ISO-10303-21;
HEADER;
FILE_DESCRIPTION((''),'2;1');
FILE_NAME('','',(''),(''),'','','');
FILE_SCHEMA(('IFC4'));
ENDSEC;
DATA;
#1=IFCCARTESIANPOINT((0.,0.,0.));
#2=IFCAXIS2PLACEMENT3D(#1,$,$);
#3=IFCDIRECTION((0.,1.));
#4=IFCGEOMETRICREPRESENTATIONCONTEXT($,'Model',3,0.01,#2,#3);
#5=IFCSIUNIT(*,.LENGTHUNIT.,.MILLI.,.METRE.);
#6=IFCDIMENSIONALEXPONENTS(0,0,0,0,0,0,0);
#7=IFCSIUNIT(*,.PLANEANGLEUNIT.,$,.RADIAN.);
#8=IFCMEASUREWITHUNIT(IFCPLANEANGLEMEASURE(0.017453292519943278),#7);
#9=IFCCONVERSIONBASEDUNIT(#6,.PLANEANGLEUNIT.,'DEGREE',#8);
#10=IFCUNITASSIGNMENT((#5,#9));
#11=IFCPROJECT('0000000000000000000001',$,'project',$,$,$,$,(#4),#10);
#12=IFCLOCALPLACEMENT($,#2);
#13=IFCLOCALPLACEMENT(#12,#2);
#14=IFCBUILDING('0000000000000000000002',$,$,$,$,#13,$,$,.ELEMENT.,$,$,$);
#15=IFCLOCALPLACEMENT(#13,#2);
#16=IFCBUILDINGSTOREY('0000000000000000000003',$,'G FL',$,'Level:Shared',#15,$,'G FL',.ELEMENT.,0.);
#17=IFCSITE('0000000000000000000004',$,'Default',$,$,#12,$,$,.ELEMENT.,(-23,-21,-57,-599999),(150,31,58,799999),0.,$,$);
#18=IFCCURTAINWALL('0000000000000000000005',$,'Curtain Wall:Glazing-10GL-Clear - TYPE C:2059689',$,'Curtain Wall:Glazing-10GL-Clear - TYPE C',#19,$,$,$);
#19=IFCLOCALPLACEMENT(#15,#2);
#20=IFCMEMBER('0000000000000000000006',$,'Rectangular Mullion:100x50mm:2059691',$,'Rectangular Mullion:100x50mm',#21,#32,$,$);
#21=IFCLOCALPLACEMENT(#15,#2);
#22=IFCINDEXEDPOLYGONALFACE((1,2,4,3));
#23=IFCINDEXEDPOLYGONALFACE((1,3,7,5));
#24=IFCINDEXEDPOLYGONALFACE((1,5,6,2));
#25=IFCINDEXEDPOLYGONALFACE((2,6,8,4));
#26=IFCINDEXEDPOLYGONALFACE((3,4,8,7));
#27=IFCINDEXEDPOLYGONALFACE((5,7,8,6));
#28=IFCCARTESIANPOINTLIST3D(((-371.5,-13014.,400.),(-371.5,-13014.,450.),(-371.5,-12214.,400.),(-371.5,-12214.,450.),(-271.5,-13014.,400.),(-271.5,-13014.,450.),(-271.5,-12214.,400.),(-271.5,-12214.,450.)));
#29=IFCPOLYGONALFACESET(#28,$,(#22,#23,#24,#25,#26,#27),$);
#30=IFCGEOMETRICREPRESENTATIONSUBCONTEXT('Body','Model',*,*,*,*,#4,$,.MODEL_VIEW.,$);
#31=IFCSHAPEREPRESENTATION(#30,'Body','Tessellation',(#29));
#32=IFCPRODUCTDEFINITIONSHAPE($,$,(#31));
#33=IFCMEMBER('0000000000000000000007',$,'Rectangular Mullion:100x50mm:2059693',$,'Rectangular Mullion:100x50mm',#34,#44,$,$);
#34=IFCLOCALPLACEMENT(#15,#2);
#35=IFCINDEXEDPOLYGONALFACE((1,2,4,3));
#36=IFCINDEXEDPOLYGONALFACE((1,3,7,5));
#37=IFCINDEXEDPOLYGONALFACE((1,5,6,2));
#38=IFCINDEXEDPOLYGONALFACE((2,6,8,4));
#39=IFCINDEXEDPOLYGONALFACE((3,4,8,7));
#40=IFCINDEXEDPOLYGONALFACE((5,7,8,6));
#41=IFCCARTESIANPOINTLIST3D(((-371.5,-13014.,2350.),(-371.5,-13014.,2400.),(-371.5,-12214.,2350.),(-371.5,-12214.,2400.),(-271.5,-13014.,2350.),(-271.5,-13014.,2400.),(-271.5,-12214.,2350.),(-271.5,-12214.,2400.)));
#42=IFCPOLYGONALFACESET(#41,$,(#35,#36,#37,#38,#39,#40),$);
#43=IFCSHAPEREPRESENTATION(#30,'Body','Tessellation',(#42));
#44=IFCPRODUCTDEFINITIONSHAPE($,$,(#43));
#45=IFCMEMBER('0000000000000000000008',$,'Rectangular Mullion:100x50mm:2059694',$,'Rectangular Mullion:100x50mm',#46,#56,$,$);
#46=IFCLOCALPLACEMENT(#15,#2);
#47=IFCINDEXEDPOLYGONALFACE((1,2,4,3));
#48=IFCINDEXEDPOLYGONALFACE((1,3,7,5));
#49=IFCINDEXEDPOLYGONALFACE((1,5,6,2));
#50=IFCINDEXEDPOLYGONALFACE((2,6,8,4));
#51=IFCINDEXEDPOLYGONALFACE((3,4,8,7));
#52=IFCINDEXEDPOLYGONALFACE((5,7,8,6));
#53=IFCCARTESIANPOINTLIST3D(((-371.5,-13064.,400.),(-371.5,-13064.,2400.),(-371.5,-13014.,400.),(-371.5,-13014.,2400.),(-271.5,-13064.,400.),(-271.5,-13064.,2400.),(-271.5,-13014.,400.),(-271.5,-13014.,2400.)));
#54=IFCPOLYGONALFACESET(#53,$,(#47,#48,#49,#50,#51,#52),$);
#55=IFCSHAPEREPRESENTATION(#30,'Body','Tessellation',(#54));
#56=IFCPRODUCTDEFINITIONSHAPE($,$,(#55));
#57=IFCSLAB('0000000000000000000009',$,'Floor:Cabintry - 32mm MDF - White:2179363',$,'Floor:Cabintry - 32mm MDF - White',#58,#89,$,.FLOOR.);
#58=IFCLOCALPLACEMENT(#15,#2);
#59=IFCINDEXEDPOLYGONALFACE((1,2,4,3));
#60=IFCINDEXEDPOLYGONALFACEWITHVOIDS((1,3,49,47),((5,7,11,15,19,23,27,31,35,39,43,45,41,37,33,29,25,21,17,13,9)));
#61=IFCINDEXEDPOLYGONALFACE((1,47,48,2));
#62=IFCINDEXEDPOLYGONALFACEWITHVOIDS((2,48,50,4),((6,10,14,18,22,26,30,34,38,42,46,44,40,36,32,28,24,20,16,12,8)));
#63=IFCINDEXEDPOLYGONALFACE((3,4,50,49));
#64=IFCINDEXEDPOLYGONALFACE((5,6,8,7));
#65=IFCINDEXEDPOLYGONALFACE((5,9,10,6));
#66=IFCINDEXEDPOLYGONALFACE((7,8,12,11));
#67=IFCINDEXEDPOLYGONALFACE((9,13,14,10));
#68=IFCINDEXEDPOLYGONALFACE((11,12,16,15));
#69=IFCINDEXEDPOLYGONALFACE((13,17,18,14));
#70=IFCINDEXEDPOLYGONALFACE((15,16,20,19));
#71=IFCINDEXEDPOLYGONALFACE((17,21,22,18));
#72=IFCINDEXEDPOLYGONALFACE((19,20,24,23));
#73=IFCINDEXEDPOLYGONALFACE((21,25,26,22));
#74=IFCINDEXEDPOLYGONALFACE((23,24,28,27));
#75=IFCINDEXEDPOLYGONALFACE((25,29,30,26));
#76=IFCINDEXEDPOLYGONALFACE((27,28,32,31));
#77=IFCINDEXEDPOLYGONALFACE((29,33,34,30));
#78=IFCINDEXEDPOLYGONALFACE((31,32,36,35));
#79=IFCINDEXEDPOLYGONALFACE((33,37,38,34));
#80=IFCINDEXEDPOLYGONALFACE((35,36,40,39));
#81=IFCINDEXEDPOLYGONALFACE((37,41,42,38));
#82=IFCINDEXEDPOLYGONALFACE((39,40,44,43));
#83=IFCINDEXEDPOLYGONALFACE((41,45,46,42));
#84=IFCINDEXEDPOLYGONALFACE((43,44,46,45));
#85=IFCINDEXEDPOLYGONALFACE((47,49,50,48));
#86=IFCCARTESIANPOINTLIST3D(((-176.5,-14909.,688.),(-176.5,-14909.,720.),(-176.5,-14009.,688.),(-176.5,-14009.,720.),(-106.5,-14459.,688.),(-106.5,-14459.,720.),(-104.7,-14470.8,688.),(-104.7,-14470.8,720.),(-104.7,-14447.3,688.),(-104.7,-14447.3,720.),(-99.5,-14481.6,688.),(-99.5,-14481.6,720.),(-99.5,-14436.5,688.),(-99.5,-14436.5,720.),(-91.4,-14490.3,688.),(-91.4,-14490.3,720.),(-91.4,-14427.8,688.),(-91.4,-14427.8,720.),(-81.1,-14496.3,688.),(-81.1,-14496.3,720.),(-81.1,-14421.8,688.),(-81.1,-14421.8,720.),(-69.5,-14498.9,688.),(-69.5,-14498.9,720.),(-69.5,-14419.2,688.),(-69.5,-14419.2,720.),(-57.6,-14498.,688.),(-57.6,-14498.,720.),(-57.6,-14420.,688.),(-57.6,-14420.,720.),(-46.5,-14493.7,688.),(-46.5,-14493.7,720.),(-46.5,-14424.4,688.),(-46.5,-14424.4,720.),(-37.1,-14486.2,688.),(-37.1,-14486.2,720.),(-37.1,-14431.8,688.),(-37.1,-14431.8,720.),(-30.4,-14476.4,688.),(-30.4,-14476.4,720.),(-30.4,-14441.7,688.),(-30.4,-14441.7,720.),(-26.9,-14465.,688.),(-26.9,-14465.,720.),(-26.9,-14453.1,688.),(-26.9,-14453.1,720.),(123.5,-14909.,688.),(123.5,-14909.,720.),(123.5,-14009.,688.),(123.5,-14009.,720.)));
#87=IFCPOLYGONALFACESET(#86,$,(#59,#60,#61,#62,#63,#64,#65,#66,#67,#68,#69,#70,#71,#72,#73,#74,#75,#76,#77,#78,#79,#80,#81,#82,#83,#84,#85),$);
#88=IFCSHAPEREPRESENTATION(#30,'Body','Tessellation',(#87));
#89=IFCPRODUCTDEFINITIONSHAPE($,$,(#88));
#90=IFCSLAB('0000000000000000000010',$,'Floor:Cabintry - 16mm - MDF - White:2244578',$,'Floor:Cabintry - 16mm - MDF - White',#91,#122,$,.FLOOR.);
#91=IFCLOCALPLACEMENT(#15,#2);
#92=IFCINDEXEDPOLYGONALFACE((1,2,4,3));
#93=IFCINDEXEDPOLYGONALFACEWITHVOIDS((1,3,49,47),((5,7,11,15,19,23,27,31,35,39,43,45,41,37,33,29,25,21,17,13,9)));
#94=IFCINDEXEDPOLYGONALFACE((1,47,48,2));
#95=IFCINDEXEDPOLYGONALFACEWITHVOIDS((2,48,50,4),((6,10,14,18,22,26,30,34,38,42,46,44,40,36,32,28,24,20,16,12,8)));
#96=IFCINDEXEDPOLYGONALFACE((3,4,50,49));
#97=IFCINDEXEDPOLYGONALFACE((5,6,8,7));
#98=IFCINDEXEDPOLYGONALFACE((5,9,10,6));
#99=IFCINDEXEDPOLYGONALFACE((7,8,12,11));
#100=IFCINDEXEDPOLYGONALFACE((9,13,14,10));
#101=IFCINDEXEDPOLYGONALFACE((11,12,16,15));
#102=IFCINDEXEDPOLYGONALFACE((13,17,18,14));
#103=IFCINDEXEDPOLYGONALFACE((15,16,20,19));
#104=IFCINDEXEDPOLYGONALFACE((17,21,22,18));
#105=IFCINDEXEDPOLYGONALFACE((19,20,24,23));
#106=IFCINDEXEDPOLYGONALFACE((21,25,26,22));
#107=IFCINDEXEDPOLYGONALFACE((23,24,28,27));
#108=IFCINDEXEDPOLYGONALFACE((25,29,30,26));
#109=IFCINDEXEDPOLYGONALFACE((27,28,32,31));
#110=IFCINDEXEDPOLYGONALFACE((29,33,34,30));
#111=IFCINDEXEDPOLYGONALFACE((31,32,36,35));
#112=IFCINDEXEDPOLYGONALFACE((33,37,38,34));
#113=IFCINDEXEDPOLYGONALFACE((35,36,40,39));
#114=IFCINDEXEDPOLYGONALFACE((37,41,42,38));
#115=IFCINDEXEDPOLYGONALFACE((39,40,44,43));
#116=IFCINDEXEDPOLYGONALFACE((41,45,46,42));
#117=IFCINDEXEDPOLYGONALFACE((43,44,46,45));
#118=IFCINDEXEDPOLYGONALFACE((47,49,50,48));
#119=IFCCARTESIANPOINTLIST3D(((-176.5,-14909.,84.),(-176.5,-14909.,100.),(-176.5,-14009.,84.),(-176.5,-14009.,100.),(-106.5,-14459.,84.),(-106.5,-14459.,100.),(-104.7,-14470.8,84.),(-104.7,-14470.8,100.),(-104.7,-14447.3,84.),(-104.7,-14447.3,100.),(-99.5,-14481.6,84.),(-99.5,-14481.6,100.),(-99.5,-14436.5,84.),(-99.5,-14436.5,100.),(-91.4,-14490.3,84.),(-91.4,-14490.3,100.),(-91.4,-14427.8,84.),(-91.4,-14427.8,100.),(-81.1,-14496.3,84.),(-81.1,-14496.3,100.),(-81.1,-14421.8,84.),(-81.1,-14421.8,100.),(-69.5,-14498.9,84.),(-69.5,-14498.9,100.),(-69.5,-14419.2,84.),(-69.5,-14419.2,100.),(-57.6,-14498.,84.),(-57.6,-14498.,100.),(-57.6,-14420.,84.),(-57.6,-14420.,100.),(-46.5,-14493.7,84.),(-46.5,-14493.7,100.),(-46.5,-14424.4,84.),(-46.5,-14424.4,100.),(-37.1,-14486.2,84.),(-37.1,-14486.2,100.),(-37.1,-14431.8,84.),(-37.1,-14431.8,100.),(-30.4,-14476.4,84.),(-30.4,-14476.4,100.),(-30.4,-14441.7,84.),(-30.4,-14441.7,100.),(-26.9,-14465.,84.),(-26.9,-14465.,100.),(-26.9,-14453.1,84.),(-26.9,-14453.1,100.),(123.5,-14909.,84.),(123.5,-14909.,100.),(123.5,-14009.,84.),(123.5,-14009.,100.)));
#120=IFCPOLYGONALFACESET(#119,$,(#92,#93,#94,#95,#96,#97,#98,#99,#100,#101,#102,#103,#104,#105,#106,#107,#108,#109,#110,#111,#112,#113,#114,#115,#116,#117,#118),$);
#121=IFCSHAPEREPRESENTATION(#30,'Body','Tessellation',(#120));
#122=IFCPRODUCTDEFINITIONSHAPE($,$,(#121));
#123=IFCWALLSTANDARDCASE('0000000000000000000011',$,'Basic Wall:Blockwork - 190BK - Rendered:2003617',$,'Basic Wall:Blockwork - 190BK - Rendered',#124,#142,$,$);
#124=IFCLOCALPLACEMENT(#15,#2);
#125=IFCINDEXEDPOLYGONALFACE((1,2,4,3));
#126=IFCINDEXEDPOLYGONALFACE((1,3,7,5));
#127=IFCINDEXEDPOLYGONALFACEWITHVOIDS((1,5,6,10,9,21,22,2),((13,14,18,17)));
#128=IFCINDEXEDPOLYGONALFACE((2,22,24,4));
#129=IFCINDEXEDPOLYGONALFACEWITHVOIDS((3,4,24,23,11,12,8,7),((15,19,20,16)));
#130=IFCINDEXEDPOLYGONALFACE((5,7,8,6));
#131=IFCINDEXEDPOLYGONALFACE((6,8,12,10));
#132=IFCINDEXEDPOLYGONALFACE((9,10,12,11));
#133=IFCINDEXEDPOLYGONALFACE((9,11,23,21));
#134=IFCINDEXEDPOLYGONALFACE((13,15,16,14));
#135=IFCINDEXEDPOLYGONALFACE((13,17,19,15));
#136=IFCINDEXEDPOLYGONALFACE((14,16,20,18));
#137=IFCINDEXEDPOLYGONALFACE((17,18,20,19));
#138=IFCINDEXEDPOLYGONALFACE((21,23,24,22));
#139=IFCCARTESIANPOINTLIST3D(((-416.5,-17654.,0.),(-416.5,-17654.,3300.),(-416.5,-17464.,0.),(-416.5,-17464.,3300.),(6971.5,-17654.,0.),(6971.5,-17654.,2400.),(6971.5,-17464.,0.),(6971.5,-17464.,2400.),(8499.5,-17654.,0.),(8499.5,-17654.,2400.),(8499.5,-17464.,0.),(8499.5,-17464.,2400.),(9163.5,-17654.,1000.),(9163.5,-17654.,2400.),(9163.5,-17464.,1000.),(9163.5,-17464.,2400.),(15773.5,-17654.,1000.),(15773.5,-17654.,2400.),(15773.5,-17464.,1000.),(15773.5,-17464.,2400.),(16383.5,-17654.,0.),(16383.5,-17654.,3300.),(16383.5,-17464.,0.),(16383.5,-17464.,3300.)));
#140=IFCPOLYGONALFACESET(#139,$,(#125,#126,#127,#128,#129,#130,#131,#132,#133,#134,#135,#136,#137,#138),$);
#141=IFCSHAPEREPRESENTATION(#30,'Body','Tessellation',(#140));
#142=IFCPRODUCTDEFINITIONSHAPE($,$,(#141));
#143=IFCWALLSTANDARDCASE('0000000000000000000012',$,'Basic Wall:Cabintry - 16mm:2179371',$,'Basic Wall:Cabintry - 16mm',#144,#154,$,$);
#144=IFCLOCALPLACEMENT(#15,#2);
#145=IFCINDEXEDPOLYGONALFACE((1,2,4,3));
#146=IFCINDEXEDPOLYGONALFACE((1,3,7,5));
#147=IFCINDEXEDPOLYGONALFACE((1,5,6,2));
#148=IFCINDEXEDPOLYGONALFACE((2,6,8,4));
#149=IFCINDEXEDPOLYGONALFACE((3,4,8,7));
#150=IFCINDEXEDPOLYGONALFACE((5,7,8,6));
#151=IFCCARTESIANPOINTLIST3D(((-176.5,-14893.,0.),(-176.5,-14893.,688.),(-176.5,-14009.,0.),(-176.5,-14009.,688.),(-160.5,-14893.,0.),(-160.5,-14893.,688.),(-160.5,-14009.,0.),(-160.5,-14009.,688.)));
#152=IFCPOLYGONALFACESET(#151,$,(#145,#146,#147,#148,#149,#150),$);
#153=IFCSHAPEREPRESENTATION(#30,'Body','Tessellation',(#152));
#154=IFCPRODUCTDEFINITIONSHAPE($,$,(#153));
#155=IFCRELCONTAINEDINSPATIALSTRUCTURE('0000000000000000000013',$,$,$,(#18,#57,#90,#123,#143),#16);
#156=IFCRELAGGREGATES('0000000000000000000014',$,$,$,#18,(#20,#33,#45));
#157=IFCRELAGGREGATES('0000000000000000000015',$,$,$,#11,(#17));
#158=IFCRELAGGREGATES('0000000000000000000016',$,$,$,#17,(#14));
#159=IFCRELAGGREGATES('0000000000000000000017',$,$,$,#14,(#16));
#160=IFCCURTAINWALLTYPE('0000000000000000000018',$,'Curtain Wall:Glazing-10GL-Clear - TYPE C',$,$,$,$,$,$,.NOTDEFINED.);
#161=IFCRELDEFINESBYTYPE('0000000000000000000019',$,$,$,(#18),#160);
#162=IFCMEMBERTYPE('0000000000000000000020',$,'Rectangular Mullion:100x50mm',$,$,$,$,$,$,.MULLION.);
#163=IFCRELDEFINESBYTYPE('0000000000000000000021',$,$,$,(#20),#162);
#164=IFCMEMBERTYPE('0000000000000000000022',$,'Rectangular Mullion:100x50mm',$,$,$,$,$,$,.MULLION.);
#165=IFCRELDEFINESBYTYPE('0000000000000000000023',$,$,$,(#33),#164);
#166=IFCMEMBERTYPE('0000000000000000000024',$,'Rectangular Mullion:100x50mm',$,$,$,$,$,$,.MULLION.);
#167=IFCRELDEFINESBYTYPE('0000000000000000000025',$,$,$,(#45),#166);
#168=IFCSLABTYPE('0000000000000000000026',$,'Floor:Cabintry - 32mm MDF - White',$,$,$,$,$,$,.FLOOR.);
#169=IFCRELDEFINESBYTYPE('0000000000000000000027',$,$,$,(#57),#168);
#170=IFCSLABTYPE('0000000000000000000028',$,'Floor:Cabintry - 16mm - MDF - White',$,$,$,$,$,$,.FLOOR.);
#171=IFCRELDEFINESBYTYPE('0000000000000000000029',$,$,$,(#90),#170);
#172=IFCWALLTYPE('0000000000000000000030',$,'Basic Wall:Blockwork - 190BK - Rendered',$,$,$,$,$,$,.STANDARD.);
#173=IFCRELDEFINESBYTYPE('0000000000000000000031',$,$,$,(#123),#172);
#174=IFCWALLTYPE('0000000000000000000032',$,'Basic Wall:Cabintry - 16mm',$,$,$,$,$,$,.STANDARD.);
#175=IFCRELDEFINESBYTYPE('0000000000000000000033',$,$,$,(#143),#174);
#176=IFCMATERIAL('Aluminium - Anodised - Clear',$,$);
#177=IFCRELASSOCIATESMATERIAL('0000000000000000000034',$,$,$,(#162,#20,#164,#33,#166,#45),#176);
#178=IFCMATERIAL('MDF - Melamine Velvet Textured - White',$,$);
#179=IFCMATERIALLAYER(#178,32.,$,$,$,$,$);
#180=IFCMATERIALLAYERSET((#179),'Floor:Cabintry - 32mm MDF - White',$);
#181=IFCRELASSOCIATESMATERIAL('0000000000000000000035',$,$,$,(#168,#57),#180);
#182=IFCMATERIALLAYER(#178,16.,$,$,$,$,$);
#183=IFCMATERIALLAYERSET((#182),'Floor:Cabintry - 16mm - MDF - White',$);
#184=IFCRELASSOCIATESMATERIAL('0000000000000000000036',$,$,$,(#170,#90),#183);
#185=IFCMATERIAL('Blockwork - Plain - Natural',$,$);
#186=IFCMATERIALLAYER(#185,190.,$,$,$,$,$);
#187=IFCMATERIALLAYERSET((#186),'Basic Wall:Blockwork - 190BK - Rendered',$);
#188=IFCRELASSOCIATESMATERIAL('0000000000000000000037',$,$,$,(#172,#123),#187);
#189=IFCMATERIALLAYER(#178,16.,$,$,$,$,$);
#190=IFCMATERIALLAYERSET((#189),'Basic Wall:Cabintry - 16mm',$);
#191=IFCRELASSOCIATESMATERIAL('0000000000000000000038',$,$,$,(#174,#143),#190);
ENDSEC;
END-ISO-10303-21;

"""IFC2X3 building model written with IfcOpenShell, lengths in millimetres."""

from ifc_helpers import new_model, entity, si_unit, converted_unit, direction, frame, frame_2d, origin, origin_2d_with_axis, place, context, subcontext, project, spatial, rectangle, circle, extrude, source, transform, mapped, material, layer, layer_set, layer_usage, type_object, type_shapes, element, aggregate, save


model = new_model("IFC2X3")

# Units and contexts
model_context = context("Model", 3, precision=0.01, world=origin(), true_north=direction((0.0, 1.0)))
body_context = subcontext(model_context, "Body", "Model", "MODEL_VIEW")
ifc_project = project(units=[si_unit("LENGTHUNIT", "METRE", prefix="MILLI"), converted_unit("PLANEANGLEUNIT", "DEGREE", entity("IfcPlaneAngleMeasure", 0.017453292519943278), si_unit("PLANEANGLEUNIT", "RADIAN"), dimensions=[0, 0, 0, 0, 0, 0, 0])], contexts=[model_context])

# Site, building, storey
site_placement = place(None, origin())
site = spatial("IfcSite", under=ifc_project, at=site_placement, Name="Default", CompositionType="ELEMENT", RefLatitude=(-23, -21, -57, -599999), RefLongitude=(150, 31, 58, 799999), RefElevation=0.0)
building_placement = place(site_placement, origin())
building = spatial("IfcBuilding", under=site, at=building_placement, CompositionType="ELEMENT")
storey_placement = place(building_placement, origin())
storey = spatial("IfcBuildingStorey", under=building, at=storey_placement, Name="G FL", ObjectType="Level:Shared", LongName="G FL", CompositionType="ELEMENT", Elevation=0.0)

# Curtain wall, members
curtain_wall_type = type_object("IfcCurtainWallType", Name="Curtain Wall:Glazing-10GL-Clear - TYPE C", PredefinedType="NOTDEFINED")
curtain_wall_placement = place(storey_placement, origin())
curtain_wall = element("IfcCurtainWall", 1, at=curtain_wall_placement, inside=storey, type_object=curtain_wall_type, Name="Curtain Wall:Glazing-10GL-Clear - TYPE C:2059689", ObjectType="Curtain Wall:Glazing-10GL-Clear - TYPE C")
ifc_material_1 = material(Name="Aluminium - Anodised - Clear")
member_type_1 = type_object("IfcMemberType", Name="Rectangular Mullion:100x50mm", PredefinedType="MULLION", material=ifc_material_1)
shared_shape_1 = source(origin(), body_context, "Body", "SweptSolid", [
    extrude(rectangle(XDim=50.0, YDim=100.0, at=origin_2d_with_axis()), frame((-25.0, 0.0, -800.0), z_axis=(0.0, 0.0, 1.0), x_axis=(-1.0, 0.0, 0.0)), (0.0, 0.0, 1.0), 800.0),
])
type_shapes(member_type_1, [shared_shape_1])
member_1_placement = place(curtain_wall_placement, frame((-321.5, -13014.0, 400.0), z_axis=(0.0, -1.0, 0.0), x_axis=(0.0, 0.0, -1.0)))
member_1 = element("IfcMember", 2, at=member_1_placement, type_object=member_type_1, material=ifc_material_1, Name="Rectangular Mullion:100x50mm:2059691", ObjectType="Rectangular Mullion:100x50mm", context=body_context, shape_type="MappedRepresentation", body=[
    mapped(shared_shape_1, transform((0.0, 0.0, 0.0), scale=1.0)),
])
member_type_2 = type_object("IfcMemberType", Name="Rectangular Mullion:100x50mm", PredefinedType="MULLION", material=ifc_material_1)
shared_shape_2 = source(origin(), body_context, "Body", "SweptSolid", [
    extrude(rectangle(XDim=50.0, YDim=100.0, at=frame_2d((0.0, 0.0), x_axis=(1.0, 0.0))), frame((-25.0, 0.0, -800.0), z_axis=(0.0, 0.0, 1.0), x_axis=(-1.0, 0.0, 0.0)), (0.0, 0.0, 1.0), 800.0),
])
type_shapes(member_type_2, [shared_shape_2])
member_2_placement = place(curtain_wall_placement, frame((-321.5, -12214.0, 2400.0), z_axis=(0.0, 1.0, 0.0), x_axis=(0.0, 0.0, 1.0)))
member_2 = element("IfcMember", 3, at=member_2_placement, type_object=member_type_2, material=ifc_material_1, Name="Rectangular Mullion:100x50mm:2059693", ObjectType="Rectangular Mullion:100x50mm", context=body_context, shape_type="MappedRepresentation", body=[
    mapped(shared_shape_2, transform((0.0, 0.0, 0.0), scale=1.0)),
])
member_type_3 = type_object("IfcMemberType", Name="Rectangular Mullion:100x50mm", PredefinedType="MULLION", material=ifc_material_1)
shared_shape_3 = source(origin(), body_context, "Body", "SweptSolid", [
    extrude(rectangle(XDim=50.0, YDim=100.0, at=frame_2d((0.0, 0.0), x_axis=(1.0, 0.0))), frame((-25.0, 0.0, -2000.0), z_axis=(0.0, 0.0, 1.0), x_axis=(-1.0, 0.0, 0.0)), (0.0, 0.0, 1.0), 2000.0),
])
type_shapes(member_type_3, [shared_shape_3])
member_3_placement = place(curtain_wall_placement, frame((-321.5, -13064.0, 2400.0), z_axis=(0.0, 0.0, 1.0), x_axis=(0.0, -1.0, 0.0)))
member_3 = element("IfcMember", 4, at=member_3_placement, type_object=member_type_3, material=ifc_material_1, Name="Rectangular Mullion:100x50mm:2059694", ObjectType="Rectangular Mullion:100x50mm", context=body_context, shape_type="MappedRepresentation", body=[
    mapped(shared_shape_3, transform((0.0, 0.0, 0.0), scale=1.0)),
])
aggregate(curtain_wall, [member_1, member_2, member_3])

# Slabs, openings
ifc_material_2 = material(Name="MDF - Melamine Velvet Textured - White")
ifc_layer_1 = layer(ifc_material_2, 32.0)
ifc_layer_set_1 = layer_set([ifc_layer_1], Name="Floor:Cabintry - 32mm MDF - White")
ifc_layer_usage_1 = layer_usage(ifc_layer_set_1, "AXIS3", "POSITIVE", 0.0)
slab_type_1 = type_object("IfcSlabType", Name="Floor:Cabintry - 32mm MDF - White", PredefinedType="FLOOR", material=ifc_layer_set_1)
slab_1_placement = place(storey_placement, frame((-176.5, -14909.0, 688.0)))
slab_1 = element("IfcSlab", 5, at=slab_1_placement, inside=storey, type_object=slab_type_1, material=ifc_layer_usage_1, Name="Floor:Cabintry - 32mm MDF - White:2179363", ObjectType="Floor:Cabintry - 32mm MDF - White", PredefinedType="FLOOR", context=body_context, shape_type="SweptSolid", body=[
    extrude(rectangle(XDim=900.0, YDim=300.0, at=frame_2d((0.0, 0.0), x_axis=(0.0, -1.0))), frame((150.0, 450.0, 32.0), z_axis=(0.0, 0.0, -1.0), x_axis=(-1.0, 0.0, 0.0)), (0.0, 0.0, 1.0), 32.0),
])
opening_1_placement = place(slab_1_placement, origin())
element("IfcOpeningElement", 6, at=opening_1_placement, cuts=slab_1, ObjectType="Opening", context=body_context, shape_type="SweptSolid", body=[
    extrude(circle(Radius=40.0, at=frame_2d((40.0, 0.0), x_axis=(1.0, 0.0))), frame((150.0, 450.0, 32.0), z_axis=(0.0, 0.0, -1.0), x_axis=(-1.0, 0.0, 0.0)), (0.0, 0.0, 1.0), 32.0),
])
ifc_layer_2 = layer(ifc_material_2, 16.0)
ifc_layer_set_2 = layer_set([ifc_layer_2], Name="Floor:Cabintry - 16mm - MDF - White")
ifc_layer_usage_2 = layer_usage(ifc_layer_set_2, "AXIS3", "POSITIVE", 0.0)
slab_type_2 = type_object("IfcSlabType", Name="Floor:Cabintry - 16mm - MDF - White", PredefinedType="FLOOR", material=ifc_layer_set_2)
slab_2_placement = place(storey_placement, frame((-176.5, -14909.0, 84.0)))
slab_2 = element("IfcSlab", 7, at=slab_2_placement, inside=storey, type_object=slab_type_2, material=ifc_layer_usage_2, Name="Floor:Cabintry - 16mm - MDF - White:2244578", ObjectType="Floor:Cabintry - 16mm - MDF - White", PredefinedType="FLOOR", context=body_context, shape_type="SweptSolid", body=[
    extrude(rectangle(XDim=900.0, YDim=300.0, at=frame_2d((0.0, 0.0), x_axis=(0.0, -1.0))), frame((150.0, 450.0, 16.0), z_axis=(0.0, 0.0, -1.0), x_axis=(-1.0, 0.0, 0.0)), (0.0, 0.0, 1.0), 16.0),
])
opening_2_placement = place(slab_2_placement, origin())
element("IfcOpeningElement", 8, at=opening_2_placement, cuts=slab_2, ObjectType="Opening", context=body_context, shape_type="SweptSolid", body=[
    extrude(circle(Radius=40.0, at=frame_2d((40.0, 0.0), x_axis=(1.0, 0.0))), frame((150.0, 450.0, 16.0), z_axis=(0.0, 0.0, -1.0), x_axis=(-1.0, 0.0, 0.0)), (0.0, 0.0, 1.0), 16.0),
])

# Wall, openings
ifc_material_3 = material(Name="Blockwork - Plain - Natural")
ifc_layer_3 = layer(ifc_material_3, 190.0)
ifc_layer_set_3 = layer_set([ifc_layer_3], Name="Basic Wall:Blockwork - 190BK - Rendered")
ifc_layer_usage_3 = layer_usage(ifc_layer_set_3, "AXIS2", "POSITIVE", -95.0)
wall_type_1 = type_object("IfcWallType", Name="Basic Wall:Blockwork - 190BK - Rendered", PredefinedType="STANDARD", material=ifc_layer_set_3)
wall_1_placement = place(storey_placement, frame((-416.5, -17559.0, 0.0)))
wall_1 = element("IfcWallStandardCase", 9, at=wall_1_placement, inside=storey, type_object=wall_type_1, material=ifc_layer_usage_3, Name="Basic Wall:Blockwork - 190BK - Rendered:2003617", ObjectType="Basic Wall:Blockwork - 190BK - Rendered", context=body_context, shape_type="SweptSolid", body=[
    extrude(rectangle(XDim=16800.0, YDim=190.0, at=frame_2d((8400.0, 0.0), x_axis=(-1.0, 0.0))), origin(), (0.0, 0.0, 1.0), 3300.0),
])
opening_3_placement = place(wall_1_placement, origin())
element("IfcOpeningElement", 10, at=opening_3_placement, cuts=wall_1, ObjectType="Opening", context=body_context, shape_type="SweptSolid", body=[
    extrude(rectangle(XDim=1400.0, YDim=6610.0, at=frame_2d((0.0, 0.0), x_axis=(0.0, 1.0))), frame((12885.0, -247.4, 1700.0), z_axis=(0.0, 1.0, 0.0), x_axis=(-1.0, 0.0, 0.0)), (0.0, 0.0, 1.0), 494.8),
])
opening_4_placement = place(wall_1_placement, frame((7388.0, -95.0, 0.0)))
element("IfcOpeningElement", 11, at=opening_4_placement, cuts=wall_1, ObjectType="Opening", context=body_context, shape_type="SweptSolid", body=[
    extrude(rectangle(XDim=2400.0, YDim=1528.0, at=frame_2d((1200.0, 764.0), x_axis=(1.0, 0.0))), frame((0.0, 0.0, 0.0), z_axis=(0.0, 1.0, 0.0), x_axis=(0.0, 0.0, 1.0)), (0.0, 0.0, 1.0), 190.0),
])

# Wall
ifc_layer_4 = layer(ifc_material_2, 16.0)
ifc_layer_set_4 = layer_set([ifc_layer_4], Name="Basic Wall:Cabintry - 16mm")
ifc_layer_usage_4 = layer_usage(ifc_layer_set_4, "AXIS2", "NEGATIVE", 8.0)
wall_type_2 = type_object("IfcWallType", Name="Basic Wall:Cabintry - 16mm", PredefinedType="STANDARD", material=ifc_layer_set_4)
wall_2_placement = place(storey_placement, frame((-168.5, -14893.0, 0.0), z_axis=(0.0, 0.0, 1.0), x_axis=(0.0, 1.0, 0.0)))
element("IfcWallStandardCase", 12, at=wall_2_placement, inside=storey, type_object=wall_type_2, material=ifc_layer_usage_4, Name="Basic Wall:Cabintry - 16mm:2179371", ObjectType="Basic Wall:Cabintry - 16mm", context=body_context, shape_type="SweptSolid", body=[
    extrude(rectangle(XDim=884.0, YDim=16.0, at=frame_2d((442.0, 0.0), x_axis=(-1.0, 0.0))), origin(), (0.0, 0.0, 1.0), 688.0),
])

save(model, "model.ifc")
